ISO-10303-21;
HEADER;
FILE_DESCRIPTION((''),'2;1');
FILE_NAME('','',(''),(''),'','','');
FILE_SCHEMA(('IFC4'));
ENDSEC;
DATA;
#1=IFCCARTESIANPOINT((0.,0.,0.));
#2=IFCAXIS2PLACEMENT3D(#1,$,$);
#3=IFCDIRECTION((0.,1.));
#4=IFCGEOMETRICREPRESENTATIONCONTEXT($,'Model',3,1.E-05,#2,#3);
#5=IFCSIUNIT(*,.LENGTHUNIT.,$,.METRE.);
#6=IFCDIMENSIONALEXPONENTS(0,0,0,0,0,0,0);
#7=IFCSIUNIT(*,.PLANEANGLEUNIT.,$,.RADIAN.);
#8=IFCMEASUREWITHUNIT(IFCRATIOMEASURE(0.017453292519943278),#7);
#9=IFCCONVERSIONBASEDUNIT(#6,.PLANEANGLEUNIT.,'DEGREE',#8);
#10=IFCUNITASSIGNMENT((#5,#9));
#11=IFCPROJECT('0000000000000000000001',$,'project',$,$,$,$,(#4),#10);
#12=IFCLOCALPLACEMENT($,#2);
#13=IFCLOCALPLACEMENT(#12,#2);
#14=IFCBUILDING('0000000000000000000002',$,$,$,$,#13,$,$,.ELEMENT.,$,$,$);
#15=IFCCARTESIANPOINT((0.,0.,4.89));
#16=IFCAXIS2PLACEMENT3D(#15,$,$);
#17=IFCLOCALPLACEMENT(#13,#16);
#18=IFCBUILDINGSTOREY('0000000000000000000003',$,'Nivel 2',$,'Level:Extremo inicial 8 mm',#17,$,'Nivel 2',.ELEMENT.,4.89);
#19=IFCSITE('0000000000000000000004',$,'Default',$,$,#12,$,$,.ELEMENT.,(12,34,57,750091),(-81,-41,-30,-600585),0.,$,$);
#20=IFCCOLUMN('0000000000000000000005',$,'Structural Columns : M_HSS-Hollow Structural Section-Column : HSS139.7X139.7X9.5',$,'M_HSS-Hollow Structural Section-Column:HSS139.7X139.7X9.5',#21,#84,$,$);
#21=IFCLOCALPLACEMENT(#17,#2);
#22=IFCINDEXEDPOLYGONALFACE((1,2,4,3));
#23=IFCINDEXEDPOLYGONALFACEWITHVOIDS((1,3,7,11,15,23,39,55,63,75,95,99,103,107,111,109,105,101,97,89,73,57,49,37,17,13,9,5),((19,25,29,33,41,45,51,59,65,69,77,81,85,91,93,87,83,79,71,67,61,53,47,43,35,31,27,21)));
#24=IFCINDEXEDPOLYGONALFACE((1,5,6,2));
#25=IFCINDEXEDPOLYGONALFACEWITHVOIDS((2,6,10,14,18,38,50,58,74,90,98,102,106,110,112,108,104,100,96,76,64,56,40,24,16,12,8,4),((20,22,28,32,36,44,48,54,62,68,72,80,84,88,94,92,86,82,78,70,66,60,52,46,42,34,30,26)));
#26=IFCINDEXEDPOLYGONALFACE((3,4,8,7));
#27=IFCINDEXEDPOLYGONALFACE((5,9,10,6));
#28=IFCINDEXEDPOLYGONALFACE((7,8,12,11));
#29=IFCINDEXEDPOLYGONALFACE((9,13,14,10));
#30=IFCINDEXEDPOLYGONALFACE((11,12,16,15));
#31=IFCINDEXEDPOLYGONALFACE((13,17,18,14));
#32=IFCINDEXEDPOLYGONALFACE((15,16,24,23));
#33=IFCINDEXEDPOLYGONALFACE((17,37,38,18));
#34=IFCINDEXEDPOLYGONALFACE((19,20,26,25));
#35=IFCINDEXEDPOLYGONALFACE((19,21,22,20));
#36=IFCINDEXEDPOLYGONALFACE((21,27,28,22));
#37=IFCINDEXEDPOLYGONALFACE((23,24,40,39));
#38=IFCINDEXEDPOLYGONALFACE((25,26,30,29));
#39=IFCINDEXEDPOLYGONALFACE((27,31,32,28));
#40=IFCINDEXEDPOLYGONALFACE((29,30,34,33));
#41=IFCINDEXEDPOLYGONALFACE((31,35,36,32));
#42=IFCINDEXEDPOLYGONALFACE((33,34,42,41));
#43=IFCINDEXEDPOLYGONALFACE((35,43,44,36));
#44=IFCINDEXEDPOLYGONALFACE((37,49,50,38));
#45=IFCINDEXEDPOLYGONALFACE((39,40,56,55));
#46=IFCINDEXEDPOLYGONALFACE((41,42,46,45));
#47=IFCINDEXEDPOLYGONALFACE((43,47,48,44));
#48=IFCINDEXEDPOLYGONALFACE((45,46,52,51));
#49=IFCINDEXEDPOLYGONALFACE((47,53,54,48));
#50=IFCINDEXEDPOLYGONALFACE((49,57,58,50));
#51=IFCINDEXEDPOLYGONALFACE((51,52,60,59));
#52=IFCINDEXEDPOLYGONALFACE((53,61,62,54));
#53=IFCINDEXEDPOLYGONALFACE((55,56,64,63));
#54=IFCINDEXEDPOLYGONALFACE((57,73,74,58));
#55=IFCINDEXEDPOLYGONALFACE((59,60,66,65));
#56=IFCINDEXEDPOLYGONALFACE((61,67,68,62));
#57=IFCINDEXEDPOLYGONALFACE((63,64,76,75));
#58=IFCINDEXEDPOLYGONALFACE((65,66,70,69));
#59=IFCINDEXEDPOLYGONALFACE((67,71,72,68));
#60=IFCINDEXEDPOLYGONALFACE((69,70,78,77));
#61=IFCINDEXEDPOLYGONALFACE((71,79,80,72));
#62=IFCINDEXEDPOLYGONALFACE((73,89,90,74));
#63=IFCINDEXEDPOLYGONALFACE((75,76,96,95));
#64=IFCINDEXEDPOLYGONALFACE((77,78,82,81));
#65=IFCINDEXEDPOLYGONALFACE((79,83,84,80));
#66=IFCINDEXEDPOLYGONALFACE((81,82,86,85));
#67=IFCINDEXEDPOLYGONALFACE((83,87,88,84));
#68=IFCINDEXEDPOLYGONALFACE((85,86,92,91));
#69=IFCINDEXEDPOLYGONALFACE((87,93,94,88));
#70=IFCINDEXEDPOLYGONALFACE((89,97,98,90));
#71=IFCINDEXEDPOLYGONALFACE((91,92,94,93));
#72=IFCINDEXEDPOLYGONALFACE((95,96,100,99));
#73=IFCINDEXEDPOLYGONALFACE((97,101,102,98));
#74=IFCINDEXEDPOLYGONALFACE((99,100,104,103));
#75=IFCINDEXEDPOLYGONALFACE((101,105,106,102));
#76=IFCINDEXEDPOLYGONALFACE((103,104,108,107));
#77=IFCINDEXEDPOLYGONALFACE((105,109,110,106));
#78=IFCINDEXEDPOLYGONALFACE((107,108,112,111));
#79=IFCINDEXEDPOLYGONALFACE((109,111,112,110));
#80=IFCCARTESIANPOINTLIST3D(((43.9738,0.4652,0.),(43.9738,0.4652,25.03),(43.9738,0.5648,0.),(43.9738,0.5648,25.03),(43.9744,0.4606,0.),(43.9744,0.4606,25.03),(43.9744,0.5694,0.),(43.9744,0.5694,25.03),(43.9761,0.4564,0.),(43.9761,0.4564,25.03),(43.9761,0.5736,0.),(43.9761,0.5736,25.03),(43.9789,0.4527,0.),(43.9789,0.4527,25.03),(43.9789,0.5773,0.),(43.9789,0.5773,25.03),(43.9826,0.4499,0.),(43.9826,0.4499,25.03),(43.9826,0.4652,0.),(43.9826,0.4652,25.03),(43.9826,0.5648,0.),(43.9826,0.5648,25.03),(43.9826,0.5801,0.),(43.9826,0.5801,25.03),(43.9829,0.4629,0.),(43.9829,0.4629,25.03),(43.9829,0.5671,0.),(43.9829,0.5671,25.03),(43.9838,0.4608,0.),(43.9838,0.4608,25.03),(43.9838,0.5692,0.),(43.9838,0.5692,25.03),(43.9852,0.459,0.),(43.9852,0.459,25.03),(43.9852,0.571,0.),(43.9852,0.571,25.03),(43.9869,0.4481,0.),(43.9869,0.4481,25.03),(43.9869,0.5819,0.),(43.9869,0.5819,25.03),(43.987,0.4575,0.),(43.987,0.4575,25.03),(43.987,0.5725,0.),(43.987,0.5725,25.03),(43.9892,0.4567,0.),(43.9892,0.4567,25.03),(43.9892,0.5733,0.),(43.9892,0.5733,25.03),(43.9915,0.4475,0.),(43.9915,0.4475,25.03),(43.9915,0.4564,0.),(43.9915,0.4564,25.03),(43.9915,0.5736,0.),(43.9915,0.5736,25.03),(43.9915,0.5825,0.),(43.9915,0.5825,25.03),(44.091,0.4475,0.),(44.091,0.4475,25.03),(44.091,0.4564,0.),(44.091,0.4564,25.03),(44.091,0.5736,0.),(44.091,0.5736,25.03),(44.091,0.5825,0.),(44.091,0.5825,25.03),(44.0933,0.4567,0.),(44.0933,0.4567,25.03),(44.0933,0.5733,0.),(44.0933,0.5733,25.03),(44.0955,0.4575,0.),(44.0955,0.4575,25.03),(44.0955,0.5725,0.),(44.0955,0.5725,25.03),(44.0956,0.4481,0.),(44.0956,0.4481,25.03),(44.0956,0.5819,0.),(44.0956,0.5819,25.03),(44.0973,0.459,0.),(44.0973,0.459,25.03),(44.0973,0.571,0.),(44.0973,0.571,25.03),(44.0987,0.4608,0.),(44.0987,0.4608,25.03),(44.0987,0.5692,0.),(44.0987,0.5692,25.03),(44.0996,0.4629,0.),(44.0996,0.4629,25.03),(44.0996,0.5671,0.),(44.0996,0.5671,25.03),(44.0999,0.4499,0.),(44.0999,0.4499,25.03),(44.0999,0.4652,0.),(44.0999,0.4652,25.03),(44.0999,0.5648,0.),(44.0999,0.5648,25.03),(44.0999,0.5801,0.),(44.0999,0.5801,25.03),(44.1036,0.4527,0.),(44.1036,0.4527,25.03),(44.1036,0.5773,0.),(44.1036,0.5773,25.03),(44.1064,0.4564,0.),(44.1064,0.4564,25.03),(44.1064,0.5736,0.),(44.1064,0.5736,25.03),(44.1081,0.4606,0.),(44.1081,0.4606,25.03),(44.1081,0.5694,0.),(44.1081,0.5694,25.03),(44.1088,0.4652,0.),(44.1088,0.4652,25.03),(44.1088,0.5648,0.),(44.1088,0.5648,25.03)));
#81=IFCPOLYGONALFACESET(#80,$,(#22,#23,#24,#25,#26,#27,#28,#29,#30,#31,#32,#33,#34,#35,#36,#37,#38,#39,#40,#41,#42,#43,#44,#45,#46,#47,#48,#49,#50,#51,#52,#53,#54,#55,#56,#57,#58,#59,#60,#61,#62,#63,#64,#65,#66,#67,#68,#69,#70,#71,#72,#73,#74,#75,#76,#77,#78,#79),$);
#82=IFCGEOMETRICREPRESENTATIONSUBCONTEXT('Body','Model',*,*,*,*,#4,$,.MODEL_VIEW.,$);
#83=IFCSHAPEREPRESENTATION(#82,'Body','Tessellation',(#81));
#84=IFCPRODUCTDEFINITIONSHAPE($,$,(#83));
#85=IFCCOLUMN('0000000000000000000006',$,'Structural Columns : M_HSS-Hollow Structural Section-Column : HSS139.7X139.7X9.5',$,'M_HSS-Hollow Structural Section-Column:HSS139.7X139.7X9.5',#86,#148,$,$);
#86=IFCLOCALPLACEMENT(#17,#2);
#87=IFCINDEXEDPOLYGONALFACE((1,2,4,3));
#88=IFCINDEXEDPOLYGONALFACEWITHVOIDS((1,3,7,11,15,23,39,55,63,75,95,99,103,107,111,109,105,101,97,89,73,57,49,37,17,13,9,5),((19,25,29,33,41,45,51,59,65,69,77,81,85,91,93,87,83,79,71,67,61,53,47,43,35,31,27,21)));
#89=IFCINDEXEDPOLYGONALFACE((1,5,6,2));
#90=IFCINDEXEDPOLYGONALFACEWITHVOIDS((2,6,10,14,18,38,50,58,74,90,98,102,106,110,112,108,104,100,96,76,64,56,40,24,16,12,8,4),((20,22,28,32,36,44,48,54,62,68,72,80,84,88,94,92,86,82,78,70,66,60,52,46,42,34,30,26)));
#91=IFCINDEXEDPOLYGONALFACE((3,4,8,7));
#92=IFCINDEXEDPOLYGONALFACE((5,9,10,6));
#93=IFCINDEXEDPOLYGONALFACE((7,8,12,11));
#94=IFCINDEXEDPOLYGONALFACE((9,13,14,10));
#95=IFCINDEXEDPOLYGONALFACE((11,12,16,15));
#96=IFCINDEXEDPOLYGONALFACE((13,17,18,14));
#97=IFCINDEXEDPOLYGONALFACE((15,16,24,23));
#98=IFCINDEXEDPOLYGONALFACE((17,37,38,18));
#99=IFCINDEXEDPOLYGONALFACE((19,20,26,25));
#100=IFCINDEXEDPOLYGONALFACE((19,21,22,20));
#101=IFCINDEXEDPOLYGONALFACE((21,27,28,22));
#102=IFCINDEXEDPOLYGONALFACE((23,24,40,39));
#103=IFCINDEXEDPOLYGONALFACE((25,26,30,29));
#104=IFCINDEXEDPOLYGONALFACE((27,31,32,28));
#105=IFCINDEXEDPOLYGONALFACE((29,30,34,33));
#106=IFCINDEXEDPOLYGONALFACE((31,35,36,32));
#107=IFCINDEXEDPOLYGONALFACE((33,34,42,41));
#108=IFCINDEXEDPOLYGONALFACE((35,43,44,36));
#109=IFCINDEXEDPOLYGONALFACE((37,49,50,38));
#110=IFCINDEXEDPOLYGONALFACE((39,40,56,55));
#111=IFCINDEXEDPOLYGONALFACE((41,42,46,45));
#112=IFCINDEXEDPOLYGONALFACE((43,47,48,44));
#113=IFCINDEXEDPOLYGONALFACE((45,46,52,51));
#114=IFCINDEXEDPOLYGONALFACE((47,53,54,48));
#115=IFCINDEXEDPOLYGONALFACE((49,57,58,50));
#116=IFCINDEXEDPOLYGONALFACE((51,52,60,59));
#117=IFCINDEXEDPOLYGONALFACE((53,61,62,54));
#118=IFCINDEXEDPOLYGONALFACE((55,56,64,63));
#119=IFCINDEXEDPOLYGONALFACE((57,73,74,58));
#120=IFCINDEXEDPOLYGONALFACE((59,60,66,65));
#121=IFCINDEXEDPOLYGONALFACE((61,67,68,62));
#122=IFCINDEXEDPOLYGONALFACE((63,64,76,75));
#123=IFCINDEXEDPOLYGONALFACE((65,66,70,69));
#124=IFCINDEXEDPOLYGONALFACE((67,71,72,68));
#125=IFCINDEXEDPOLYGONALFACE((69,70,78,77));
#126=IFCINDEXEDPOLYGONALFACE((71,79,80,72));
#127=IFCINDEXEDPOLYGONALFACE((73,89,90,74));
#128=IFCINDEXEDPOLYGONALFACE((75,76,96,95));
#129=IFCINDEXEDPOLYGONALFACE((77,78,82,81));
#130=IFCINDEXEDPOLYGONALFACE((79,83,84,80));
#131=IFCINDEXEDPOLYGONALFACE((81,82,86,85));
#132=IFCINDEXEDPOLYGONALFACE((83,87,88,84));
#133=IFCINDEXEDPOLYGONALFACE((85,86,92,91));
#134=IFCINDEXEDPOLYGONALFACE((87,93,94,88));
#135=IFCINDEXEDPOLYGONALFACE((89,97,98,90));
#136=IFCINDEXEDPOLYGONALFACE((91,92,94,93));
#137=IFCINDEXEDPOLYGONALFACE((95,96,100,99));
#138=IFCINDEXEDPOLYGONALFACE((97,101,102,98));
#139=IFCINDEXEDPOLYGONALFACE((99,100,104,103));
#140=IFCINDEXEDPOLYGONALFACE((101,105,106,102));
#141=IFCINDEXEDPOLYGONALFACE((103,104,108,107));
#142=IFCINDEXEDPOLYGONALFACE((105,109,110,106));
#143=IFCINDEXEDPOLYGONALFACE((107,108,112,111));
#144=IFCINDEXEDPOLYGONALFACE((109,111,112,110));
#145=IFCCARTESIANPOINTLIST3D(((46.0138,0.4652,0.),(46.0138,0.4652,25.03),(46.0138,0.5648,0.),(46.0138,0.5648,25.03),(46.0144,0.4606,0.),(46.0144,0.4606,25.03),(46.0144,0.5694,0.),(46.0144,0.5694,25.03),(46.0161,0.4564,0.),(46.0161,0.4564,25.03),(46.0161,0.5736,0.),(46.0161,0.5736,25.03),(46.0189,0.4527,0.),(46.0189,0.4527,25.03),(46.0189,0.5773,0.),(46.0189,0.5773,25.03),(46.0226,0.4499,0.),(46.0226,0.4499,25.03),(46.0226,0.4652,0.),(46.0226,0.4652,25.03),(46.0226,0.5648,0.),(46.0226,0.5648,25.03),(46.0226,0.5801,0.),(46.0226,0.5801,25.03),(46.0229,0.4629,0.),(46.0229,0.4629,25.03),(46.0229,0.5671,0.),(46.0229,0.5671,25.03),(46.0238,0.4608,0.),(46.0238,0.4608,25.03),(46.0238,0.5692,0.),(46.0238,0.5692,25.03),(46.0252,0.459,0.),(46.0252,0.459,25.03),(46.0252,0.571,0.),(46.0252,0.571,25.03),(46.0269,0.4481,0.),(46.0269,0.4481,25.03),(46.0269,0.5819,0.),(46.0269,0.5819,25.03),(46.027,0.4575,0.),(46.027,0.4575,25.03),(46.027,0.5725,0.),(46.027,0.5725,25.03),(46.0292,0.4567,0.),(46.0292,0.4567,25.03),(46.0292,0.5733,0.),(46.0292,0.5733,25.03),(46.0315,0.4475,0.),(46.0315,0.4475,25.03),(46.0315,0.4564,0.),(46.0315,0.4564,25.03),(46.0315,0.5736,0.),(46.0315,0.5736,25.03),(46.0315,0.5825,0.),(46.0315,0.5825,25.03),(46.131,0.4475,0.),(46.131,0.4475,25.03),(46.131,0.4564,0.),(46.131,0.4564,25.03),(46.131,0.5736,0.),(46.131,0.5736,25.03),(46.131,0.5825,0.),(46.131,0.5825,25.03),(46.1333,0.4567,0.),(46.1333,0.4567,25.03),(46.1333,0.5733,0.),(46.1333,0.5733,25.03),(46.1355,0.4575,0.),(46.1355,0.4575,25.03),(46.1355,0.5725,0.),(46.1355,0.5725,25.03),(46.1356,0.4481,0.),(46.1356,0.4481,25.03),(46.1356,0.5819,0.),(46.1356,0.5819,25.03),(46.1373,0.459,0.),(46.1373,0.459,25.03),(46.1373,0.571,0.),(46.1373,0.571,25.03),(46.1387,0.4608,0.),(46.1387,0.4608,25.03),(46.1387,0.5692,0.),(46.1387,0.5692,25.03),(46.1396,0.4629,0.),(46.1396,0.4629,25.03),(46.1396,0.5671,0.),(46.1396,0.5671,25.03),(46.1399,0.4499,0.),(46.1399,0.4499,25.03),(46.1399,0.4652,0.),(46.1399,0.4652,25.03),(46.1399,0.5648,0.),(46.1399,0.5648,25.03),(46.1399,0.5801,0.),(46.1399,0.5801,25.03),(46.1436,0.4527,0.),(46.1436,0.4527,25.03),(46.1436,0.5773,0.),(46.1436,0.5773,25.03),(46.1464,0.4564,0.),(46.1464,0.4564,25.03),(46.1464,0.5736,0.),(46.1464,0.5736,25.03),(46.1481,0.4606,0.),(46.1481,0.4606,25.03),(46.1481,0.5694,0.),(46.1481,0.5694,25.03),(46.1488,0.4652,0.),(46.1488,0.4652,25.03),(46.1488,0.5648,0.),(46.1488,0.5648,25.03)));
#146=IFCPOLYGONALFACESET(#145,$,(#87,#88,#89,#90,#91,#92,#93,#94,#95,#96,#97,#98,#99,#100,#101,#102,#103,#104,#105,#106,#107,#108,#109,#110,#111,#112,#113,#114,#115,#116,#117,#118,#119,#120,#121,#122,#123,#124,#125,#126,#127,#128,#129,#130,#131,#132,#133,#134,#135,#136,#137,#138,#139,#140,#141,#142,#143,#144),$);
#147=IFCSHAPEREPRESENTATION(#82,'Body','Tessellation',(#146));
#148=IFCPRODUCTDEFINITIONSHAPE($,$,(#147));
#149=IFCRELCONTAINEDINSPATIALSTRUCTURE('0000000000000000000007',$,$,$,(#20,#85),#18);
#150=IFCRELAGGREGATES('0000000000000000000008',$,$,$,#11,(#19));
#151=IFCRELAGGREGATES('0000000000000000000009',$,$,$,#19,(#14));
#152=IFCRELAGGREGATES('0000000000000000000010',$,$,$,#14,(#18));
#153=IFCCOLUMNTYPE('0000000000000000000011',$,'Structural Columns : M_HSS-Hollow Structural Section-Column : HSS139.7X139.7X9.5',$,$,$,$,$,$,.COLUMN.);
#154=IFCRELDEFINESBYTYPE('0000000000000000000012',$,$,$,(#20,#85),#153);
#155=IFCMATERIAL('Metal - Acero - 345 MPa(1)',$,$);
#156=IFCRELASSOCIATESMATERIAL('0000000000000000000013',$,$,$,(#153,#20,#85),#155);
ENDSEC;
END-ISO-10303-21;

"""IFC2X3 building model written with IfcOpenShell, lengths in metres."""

from ifc_helpers import new_model, entity, si_unit, converted_unit, direction, frame, frame_2d, origin, place, context, subcontext, project, spatial, polyline, circle_curve, parameter, trimmed, segment, composite_curve, outline, extrude, source, transform, mapped, material, type_object, type_shapes, element, save


model = new_model("IFC2X3")

# Units and contexts
model_context = context("Model", 3, precision=1e-05, world=origin(), true_north=direction((0.0, 1.0)))
body_context = subcontext(model_context, "Body", "Model", "MODEL_VIEW")
ifc_project = project(units=[si_unit("LENGTHUNIT", "METRE"), converted_unit("PLANEANGLEUNIT", "DEGREE", entity("IfcRatioMeasure", 0.017453292519943278), si_unit("PLANEANGLEUNIT", "RADIAN"), dimensions=[0, 0, 0, 0, 0, 0, 0])], contexts=[model_context])

# Site, building, storey
site_placement = place(None, origin())
site = spatial("IfcSite", under=ifc_project, at=site_placement, Name="Default", CompositionType="ELEMENT", RefLatitude=(12, 34, 57, 750091), RefLongitude=(-81, -41, -30, -600585), RefElevation=0.0)
building_placement = place(site_placement, origin())
building = spatial("IfcBuilding", under=site, at=building_placement, CompositionType="ELEMENT")
storey_placement = place(building_placement, frame((0.0, 0.0, 4.89)))
storey = spatial("IfcBuildingStorey", under=building, at=storey_placement, Name="Nivel 2", ObjectType="Level:Extremo inicial 8 mm", LongName="Nivel 2", CompositionType="ELEMENT", Elevation=4.89)

# Columns
ifc_material_1 = material(Name="Metal - Acero - 345 MPa(1)")
column_type_1 = type_object("IfcColumnType", Name="Structural Columns : M_HSS-Hollow Structural Section-Column : HSS139.7X139.7X9.5", PredefinedType="COLUMN", material=ifc_material_1)
shared_shape_1 = source(origin(), body_context, "Body", "SweptSolid", [
    extrude(outline(composite_curve([segment(polyline([(-0.0498, -0.0675), (0.0498, -0.0675)]), True, "CONTINUOUS"), segment(trimmed(circle_curve(frame_2d((0.0498, -0.0498), x_axis=(-1.0, 0.0)), 0.0177), [parameter(90.0)], [parameter(180.0)], True, "PARAMETER"), True, "CONTINUOUS"), segment(polyline([(0.0675, -0.0498), (0.0675, 0.0498)]), True, "CONTINUOUS"), segment(trimmed(circle_curve(frame_2d((0.0498, 0.0498), x_axis=(-1.0, 0.0)), 0.0177), [parameter(180.0)], [parameter(270.0)], True, "PARAMETER"), True, "CONTINUOUS"), segment(polyline([(0.0498, 0.0675), (-0.0498, 0.0675)]), True, "CONTINUOUS"), segment(trimmed(circle_curve(frame_2d((-0.0498, 0.0498), x_axis=(-1.0, 0.0)), 0.0177), [parameter(270.0)], [parameter(360.0)], True, "PARAMETER"), True, "CONTINUOUS"), segment(polyline([(-0.0675, 0.0498), (-0.0675, -0.0498)]), True, "CONTINUOUS"), segment(trimmed(circle_curve(frame_2d((-0.0498, -0.0498), x_axis=(-1.0, 0.0)), 0.0177), [parameter(360.0)], [parameter(90.0)], True, "PARAMETER"), True, "CONTINUOUS")], self_intersect=False), holes=[composite_curve([segment(trimmed(circle_curve(frame_2d((-0.0498, -0.0498), x_axis=(-1.0, 0.0)), 0.0089), [parameter(0.0)], [parameter(90.0)], True, "PARAMETER"), False, "CONTINUOUS"), segment(polyline([(-0.0586, -0.0498), (-0.0586, 0.0498)]), True, "CONTINUOUS"), segment(trimmed(circle_curve(frame_2d((-0.0498, 0.0498), x_axis=(-1.0, 0.0)), 0.0089), [parameter(270.0)], [parameter(0.0)], True, "PARAMETER"), False, "CONTINUOUS"), segment(polyline([(-0.0498, 0.0586), (0.0498, 0.0586)]), True, "CONTINUOUS"), segment(trimmed(circle_curve(frame_2d((0.0498, 0.0498), x_axis=(-1.0, 0.0)), 0.0089), [parameter(180.0)], [parameter(270.0)], True, "PARAMETER"), False, "CONTINUOUS"), segment(polyline([(0.0586, 0.0498), (0.0586, -0.0498)]), True, "CONTINUOUS"), segment(trimmed(circle_curve(frame_2d((0.0498, -0.0498), x_axis=(-1.0, 0.0)), 0.0089), [parameter(90.0)], [parameter(180.0)], True, "PARAMETER"), False, "CONTINUOUS"), segment(polyline([(0.0498, -0.0586), (-0.0498, -0.0586)]), True, "CONTINUOUS")], self_intersect=False)]), frame((0.0, 0.0, 4.89), z_axis=(0.0, 0.0, 1.0), x_axis=(-1.0, 0.0, 0.0)), (0.0, 0.0, 1.0), 25.03),
])
type_shapes(column_type_1, [shared_shape_1])
for number, where, name in (
    (1, (44.0413, 0.515, -4.89), "Structural Columns : M_HSS-Hollow Structural Section-Column : HSS139.7X139.7X9.5"),
    (2, (46.0813, 0.515, -4.89), "Structural Columns : M_HSS-Hollow Structural Section-Column : HSS139.7X139.7X9.5"),
):
    element("IfcColumn", number, at=place(storey_placement, frame(where)), inside=storey, type_object=column_type_1, material=ifc_material_1, Name=name, ObjectType="M_HSS-Hollow Structural Section-Column:HSS139.7X139.7X9.5", context=body_context, shape_type="MappedRepresentation", body=[
        mapped(shared_shape_1, transform((0.0, 0.0, 0.0), scale=1.0)),
    ])

save(model, "model.ifc")
